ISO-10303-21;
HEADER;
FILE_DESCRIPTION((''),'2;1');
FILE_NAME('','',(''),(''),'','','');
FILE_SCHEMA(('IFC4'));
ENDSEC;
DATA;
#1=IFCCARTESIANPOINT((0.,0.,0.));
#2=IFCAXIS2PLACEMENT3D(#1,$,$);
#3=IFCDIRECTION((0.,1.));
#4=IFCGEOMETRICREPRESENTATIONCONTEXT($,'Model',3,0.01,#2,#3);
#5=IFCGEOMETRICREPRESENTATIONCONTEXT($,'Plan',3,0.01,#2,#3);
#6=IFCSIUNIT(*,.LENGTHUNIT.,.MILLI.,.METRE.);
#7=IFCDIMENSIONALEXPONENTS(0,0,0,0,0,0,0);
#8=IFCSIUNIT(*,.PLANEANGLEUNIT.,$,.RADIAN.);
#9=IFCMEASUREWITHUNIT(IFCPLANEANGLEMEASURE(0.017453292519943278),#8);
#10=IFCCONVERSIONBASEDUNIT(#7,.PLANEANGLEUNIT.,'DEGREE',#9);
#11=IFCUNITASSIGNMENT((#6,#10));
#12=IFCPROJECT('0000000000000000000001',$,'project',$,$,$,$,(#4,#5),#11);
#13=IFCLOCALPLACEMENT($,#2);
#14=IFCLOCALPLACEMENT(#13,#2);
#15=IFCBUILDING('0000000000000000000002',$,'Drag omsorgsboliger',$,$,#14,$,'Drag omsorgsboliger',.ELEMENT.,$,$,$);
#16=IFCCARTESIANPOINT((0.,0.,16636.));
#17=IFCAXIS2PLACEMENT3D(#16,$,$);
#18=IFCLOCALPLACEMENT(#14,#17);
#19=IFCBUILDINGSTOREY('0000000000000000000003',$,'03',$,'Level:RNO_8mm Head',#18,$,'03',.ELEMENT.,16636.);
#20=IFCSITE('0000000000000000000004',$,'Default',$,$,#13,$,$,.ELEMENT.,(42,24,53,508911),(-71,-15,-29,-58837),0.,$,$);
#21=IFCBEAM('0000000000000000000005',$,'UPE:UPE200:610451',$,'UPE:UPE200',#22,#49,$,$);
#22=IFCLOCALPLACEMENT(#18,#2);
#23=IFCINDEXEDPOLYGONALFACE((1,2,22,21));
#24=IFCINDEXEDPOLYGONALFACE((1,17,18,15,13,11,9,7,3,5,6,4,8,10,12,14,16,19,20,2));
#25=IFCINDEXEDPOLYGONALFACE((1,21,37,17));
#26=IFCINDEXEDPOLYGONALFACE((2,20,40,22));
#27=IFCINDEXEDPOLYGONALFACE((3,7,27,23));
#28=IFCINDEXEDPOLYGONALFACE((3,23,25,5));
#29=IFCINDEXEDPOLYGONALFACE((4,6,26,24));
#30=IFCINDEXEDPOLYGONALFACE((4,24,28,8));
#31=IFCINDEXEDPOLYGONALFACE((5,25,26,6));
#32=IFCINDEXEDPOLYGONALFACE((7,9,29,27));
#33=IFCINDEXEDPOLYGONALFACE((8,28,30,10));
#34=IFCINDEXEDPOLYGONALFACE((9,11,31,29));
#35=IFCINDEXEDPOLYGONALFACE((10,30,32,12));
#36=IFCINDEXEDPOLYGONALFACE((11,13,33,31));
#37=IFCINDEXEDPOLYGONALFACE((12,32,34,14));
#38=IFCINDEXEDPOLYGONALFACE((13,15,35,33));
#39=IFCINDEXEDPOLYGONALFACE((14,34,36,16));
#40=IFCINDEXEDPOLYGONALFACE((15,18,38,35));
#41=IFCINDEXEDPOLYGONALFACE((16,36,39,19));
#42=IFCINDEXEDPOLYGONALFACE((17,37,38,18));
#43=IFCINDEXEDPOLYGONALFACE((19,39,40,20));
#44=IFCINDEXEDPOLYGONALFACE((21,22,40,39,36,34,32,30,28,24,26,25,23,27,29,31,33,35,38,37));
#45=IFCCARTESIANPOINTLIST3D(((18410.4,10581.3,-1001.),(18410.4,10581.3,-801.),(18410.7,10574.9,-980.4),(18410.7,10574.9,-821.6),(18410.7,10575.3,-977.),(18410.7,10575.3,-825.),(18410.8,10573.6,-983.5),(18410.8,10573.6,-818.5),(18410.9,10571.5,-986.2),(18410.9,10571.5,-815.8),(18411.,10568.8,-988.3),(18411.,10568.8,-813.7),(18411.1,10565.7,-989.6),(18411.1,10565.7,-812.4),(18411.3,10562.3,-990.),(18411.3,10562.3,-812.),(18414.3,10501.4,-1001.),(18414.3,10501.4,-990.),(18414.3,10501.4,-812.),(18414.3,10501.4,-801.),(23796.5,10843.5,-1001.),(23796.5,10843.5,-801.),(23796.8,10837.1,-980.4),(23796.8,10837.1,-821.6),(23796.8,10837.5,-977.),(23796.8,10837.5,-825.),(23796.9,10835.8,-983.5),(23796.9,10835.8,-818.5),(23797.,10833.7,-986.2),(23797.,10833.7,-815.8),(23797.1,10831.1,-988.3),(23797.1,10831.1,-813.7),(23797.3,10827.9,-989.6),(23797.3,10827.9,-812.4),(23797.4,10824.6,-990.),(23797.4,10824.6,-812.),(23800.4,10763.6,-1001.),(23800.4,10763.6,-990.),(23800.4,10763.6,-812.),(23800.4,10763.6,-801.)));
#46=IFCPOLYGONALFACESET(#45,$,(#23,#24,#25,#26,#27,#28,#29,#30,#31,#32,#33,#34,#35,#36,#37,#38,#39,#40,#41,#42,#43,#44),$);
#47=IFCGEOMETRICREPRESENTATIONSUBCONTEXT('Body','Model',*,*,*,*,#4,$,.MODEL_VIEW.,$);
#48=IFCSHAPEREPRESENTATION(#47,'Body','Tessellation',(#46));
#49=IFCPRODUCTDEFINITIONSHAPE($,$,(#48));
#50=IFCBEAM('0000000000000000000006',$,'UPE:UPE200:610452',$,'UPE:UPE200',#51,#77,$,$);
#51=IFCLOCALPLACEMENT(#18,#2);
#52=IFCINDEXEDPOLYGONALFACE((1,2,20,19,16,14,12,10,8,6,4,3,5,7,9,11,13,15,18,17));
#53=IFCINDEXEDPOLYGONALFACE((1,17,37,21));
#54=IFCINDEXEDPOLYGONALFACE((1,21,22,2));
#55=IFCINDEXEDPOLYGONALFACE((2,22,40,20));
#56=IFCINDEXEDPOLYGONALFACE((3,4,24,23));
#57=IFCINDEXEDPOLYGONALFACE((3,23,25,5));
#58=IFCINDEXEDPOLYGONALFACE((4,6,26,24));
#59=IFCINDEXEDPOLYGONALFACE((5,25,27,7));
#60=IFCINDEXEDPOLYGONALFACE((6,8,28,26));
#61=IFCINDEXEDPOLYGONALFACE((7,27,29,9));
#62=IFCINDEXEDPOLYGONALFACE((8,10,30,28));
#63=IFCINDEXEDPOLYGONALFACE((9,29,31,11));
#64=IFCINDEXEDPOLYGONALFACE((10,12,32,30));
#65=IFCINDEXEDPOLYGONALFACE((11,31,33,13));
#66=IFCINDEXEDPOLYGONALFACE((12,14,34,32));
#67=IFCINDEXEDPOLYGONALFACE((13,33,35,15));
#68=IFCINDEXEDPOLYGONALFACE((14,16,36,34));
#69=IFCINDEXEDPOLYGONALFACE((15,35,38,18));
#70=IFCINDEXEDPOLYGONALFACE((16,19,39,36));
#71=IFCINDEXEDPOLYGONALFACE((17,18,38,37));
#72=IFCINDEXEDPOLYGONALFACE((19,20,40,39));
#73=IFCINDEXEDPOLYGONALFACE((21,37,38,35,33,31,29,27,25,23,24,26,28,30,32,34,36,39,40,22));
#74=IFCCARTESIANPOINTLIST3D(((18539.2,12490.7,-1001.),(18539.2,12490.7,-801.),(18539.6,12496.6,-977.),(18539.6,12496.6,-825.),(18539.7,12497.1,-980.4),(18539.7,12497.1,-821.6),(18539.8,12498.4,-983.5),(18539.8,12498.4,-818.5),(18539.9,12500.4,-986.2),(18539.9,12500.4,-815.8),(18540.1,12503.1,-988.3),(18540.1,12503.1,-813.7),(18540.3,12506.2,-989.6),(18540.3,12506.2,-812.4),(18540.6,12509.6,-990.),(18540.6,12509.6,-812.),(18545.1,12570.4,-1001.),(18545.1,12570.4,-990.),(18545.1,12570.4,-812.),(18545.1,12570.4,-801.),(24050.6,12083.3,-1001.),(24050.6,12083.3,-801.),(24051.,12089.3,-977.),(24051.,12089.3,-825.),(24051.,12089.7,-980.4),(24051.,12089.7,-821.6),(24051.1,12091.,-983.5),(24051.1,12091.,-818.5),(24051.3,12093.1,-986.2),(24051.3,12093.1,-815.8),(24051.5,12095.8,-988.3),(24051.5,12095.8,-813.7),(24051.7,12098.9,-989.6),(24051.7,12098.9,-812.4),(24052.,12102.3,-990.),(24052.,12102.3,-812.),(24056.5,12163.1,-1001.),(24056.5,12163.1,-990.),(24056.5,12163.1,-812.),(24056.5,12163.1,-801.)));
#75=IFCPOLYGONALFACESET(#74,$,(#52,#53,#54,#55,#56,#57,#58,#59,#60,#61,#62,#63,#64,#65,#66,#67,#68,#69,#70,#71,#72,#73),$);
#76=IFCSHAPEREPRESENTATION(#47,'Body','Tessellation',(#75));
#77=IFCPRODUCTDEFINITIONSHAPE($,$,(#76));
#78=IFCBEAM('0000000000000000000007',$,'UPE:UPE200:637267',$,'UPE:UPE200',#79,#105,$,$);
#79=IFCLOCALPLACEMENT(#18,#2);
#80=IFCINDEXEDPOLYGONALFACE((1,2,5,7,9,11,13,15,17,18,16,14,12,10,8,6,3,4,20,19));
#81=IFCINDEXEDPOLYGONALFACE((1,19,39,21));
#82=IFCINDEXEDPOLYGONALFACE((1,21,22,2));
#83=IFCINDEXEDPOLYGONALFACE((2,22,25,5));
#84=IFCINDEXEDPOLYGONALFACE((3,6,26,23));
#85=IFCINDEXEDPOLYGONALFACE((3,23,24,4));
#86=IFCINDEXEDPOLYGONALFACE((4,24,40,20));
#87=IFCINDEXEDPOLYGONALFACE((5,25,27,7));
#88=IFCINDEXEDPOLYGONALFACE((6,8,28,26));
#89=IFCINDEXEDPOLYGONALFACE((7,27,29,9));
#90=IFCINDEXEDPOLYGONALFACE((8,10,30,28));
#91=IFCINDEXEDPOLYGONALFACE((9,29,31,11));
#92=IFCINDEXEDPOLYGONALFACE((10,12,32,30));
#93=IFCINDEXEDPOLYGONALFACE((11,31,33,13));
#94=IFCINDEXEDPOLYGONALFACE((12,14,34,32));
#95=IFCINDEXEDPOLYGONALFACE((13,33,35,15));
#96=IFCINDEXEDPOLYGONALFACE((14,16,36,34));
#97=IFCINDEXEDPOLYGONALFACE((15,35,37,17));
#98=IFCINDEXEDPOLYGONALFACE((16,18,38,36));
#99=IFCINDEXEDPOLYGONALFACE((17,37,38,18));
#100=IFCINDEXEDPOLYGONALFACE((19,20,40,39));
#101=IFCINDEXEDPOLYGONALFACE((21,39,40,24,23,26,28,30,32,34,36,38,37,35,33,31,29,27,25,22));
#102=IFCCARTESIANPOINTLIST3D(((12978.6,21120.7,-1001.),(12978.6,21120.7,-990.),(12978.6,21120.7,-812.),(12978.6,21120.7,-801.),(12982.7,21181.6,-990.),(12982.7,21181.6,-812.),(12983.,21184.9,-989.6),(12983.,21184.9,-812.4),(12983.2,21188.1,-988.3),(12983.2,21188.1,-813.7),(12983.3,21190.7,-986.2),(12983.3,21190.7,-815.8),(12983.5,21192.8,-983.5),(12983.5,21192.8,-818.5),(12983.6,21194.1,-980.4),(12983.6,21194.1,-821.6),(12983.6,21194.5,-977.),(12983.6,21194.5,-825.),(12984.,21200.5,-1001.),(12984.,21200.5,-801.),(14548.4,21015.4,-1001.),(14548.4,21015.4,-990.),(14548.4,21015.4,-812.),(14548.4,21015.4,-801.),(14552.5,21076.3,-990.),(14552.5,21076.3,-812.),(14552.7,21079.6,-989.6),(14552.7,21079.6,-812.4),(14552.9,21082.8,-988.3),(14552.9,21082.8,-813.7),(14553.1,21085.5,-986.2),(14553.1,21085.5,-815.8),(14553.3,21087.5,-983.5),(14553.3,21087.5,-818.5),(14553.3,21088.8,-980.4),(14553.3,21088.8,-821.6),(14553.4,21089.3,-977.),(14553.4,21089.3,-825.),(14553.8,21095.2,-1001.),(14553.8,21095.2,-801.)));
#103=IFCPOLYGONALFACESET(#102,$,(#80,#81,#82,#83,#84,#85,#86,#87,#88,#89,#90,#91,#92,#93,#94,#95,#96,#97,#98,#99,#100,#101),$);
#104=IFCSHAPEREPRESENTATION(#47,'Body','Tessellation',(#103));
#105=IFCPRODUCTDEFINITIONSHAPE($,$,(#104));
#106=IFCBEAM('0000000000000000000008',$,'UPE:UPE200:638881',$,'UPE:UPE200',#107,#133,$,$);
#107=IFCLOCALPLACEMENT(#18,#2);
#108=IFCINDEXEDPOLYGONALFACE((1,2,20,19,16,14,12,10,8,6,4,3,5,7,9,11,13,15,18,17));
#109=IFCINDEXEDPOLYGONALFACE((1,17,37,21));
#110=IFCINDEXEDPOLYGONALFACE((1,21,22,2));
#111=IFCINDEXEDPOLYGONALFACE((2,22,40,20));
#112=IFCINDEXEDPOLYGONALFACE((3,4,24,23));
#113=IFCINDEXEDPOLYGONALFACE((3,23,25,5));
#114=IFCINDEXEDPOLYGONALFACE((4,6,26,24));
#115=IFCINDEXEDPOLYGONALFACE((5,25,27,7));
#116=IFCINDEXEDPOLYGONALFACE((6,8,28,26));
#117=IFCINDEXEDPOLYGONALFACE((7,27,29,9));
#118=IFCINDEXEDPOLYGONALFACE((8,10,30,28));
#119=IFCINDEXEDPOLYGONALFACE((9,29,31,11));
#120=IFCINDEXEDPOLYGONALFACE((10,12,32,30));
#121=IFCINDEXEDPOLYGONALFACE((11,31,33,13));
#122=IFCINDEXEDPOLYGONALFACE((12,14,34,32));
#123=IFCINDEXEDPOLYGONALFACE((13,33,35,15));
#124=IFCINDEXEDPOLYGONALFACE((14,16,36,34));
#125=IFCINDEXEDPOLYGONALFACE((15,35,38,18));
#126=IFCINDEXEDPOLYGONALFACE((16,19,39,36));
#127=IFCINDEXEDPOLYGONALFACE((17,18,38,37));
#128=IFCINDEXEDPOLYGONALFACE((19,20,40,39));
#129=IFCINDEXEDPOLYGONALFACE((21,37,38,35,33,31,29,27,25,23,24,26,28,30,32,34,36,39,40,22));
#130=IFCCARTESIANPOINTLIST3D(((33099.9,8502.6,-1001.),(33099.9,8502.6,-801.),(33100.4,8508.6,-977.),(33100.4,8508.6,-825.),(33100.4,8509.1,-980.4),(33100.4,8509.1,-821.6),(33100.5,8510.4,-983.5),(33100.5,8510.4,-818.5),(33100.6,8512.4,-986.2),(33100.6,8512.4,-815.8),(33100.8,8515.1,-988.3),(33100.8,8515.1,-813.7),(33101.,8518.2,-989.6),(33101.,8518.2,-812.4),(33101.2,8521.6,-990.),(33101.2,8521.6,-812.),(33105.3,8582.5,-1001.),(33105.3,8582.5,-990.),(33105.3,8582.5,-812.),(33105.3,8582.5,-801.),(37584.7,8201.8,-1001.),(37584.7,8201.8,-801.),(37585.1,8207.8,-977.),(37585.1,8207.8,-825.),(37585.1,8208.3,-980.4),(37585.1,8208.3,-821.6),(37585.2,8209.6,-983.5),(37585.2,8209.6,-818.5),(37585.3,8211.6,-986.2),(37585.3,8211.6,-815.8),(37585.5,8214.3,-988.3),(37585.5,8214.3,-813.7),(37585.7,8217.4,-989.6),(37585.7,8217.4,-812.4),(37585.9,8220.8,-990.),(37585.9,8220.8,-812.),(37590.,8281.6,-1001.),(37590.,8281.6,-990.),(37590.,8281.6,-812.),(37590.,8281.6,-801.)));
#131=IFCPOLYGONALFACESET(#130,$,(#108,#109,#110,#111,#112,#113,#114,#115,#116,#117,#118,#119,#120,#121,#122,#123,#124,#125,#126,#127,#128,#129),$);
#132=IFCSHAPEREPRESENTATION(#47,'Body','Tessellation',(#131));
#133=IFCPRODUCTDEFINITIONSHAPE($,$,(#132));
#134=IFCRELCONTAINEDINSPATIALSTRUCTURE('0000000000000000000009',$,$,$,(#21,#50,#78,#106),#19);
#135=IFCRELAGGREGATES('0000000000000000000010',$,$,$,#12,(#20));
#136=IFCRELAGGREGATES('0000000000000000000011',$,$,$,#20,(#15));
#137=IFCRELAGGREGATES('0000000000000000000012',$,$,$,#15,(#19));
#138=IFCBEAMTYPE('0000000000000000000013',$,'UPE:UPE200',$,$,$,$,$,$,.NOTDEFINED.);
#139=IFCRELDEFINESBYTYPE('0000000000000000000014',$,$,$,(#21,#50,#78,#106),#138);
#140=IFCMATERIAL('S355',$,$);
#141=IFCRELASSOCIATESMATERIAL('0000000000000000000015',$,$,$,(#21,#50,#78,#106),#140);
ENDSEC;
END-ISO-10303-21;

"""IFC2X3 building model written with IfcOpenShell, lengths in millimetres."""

from ifc_helpers import new_model, entity, si_unit, converted_unit, direction, frame, frame_2d, origin, place, context, subcontext, project, spatial, polyline, circle_curve, parameter, trimmed, segment, composite_curve, outline, extrude, material, type_object, element, save


model = new_model("IFC2X3")

# Units and contexts
model_context = context("Model", 3, precision=0.01, world=origin(), true_north=direction((0.0, 1.0)))
plan_context = context("Plan", 3, precision=0.01, world=origin(), true_north=direction((0.0, 1.0)))
body_context = subcontext(model_context, "Body", "Model", "MODEL_VIEW")
ifc_project = project(units=[si_unit("LENGTHUNIT", "METRE", prefix="MILLI"), converted_unit("PLANEANGLEUNIT", "DEGREE", entity("IfcPlaneAngleMeasure", 0.017453292519943278), si_unit("PLANEANGLEUNIT", "RADIAN"), dimensions=[0, 0, 0, 0, 0, 0, 0])], contexts=[model_context, plan_context])

# Site, building, storey
site_placement = place(None, origin())
site = spatial("IfcSite", under=ifc_project, at=site_placement, Name="Default", CompositionType="ELEMENT", RefLatitude=(42, 24, 53, 508911), RefLongitude=(-71, -15, -29, -58837), RefElevation=0.0)
building_placement = place(site_placement, origin())
building = spatial("IfcBuilding", under=site, at=building_placement, Name="Drag omsorgsboliger", LongName="Drag omsorgsboliger", CompositionType="ELEMENT")
storey_placement = place(building_placement, frame((0.0, 0.0, 16636.0)))
storey = spatial("IfcBuildingStorey", under=building, at=storey_placement, Name="03", ObjectType="Level:RNO_8mm Head", LongName="03", CompositionType="ELEMENT", Elevation=16636.0)

# Beams
ifc_material = material(Name="S355")
beam_type_1 = type_object("IfcBeamType", Name="UPE:UPE200", PredefinedType="NOTDEFINED")
beam_1_placement = place(storey_placement, frame((23879.2, 10821.9, -801.0), z_axis=(0.0, 0.0, 1.0), x_axis=(-0.998817, -0.048632, 0.0)))
element("IfcBeam", 1, at=beam_1_placement, inside=storey, type_object=beam_type_1, material=ifc_material, Name="UPE:UPE200:610451", ObjectType="UPE:UPE200", context=body_context, shape_type="SweptSolid", body=[
    extrude(outline(composite_curve([segment(polyline([(-100.0, -37.0), (100.0, -37.0)]), True, "CONTINUOUS"), segment(polyline([(100.0, -37.0), (100.0, 43.0)]), True, "CONTINUOUS"), segment(polyline([(100.0, 43.0), (89.0, 43.0)]), True, "CONTINUOUS"), segment(polyline([(89.0, 43.0), (89.0, -18.0)]), True, "CONTINUOUS"), segment(trimmed(circle_curve(frame_2d((76.0, -18.0), x_axis=(1.0, 0.0)), 13.0), [parameter(270.0)], [parameter(0.0)], True, "PARAMETER"), False, "CONTINUOUS"), segment(polyline([(76.0, -31.0), (-76.0, -31.0)]), True, "CONTINUOUS"), segment(trimmed(circle_curve(frame_2d((-76.0, -18.0), x_axis=(0.0, -1.0)), 13.0), [parameter(270.0)], [parameter(0.0)], True, "PARAMETER"), False, "CONTINUOUS"), segment(polyline([(-89.0, -18.0), (-89.0, 43.0)]), True, "CONTINUOUS"), segment(polyline([(-89.0, 43.0), (-100.0, 43.0)]), True, "CONTINUOUS"), segment(polyline([(-100.0, 43.0), (-100.0, -37.0)]), True, "CONTINUOUS")], self_intersect=False)), frame((81.5, 11.4, -100.0), z_axis=(1.0, 0.0, 0.0), x_axis=(0.0, 0.0, -1.0)), (0.0, 0.0, 1.0), 5392.5),
])
beam_2_placement = place(storey_placement, frame((18594.6, 12512.2, -801.0), z_axis=(0.0, 0.0, 1.0), x_axis=(0.99728, -0.073706, 0.0)))
element("IfcBeam", 2, at=beam_2_placement, inside=storey, type_object=beam_type_1, material=ifc_material, Name="UPE:UPE200:610452", ObjectType="UPE:UPE200", context=body_context, shape_type="SweptSolid", body=[
    extrude(outline(composite_curve([segment(polyline([(-100.0, -37.0), (100.0, -37.0)]), True, "CONTINUOUS"), segment(polyline([(100.0, -37.0), (100.0, 43.0)]), True, "CONTINUOUS"), segment(polyline([(100.0, 43.0), (89.0, 43.0)]), True, "CONTINUOUS"), segment(polyline([(89.0, 43.0), (89.0, -18.0)]), True, "CONTINUOUS"), segment(trimmed(circle_curve(frame_2d((76.0, -18.0), x_axis=(1.0, 0.0)), 13.0), [parameter(270.0)], [parameter(0.0)], True, "PARAMETER"), False, "CONTINUOUS"), segment(polyline([(76.0, -31.0), (-76.0, -31.0)]), True, "CONTINUOUS"), segment(trimmed(circle_curve(frame_2d((-76.0, -18.0), x_axis=(0.0, -1.0)), 13.0), [parameter(270.0)], [parameter(0.0)], True, "PARAMETER"), False, "CONTINUOUS"), segment(polyline([(-89.0, -18.0), (-89.0, 43.0)]), True, "CONTINUOUS"), segment(polyline([(-89.0, 43.0), (-100.0, 43.0)]), True, "CONTINUOUS"), segment(polyline([(-100.0, 43.0), (-100.0, -37.0)]), True, "CONTINUOUS")], self_intersect=False)), frame((-53.7, 11.4, -100.0), z_axis=(1.0, 0.0, 0.0), x_axis=(0.0, 0.0, -1.0)), (0.0, 0.0, 1.0), 5526.4),
])
beam_3_placement = place(storey_placement, frame((14552.1, 21069.7, -801.0), z_axis=(0.0, 0.0, 1.0), x_axis=(-0.997758, 0.066923, 0.0)))
element("IfcBeam", 3, at=beam_3_placement, inside=storey, type_object=beam_type_1, material=ifc_material, Name="UPE:UPE200:637267", ObjectType="UPE:UPE200", context=body_context, shape_type="SweptSolid", body=[
    extrude(outline(composite_curve([segment(polyline([(-100.0, -37.0), (100.0, -37.0)]), True, "CONTINUOUS"), segment(polyline([(100.0, -37.0), (100.0, 43.0)]), True, "CONTINUOUS"), segment(polyline([(100.0, 43.0), (89.0, 43.0)]), True, "CONTINUOUS"), segment(polyline([(89.0, 43.0), (89.0, -18.0)]), True, "CONTINUOUS"), segment(trimmed(circle_curve(frame_2d((76.0, -18.0), x_axis=(1.0, 0.0)), 13.0), [parameter(270.0)], [parameter(0.0)], True, "PARAMETER"), False, "CONTINUOUS"), segment(polyline([(76.0, -31.0), (-76.0, -31.0)]), True, "CONTINUOUS"), segment(trimmed(circle_curve(frame_2d((-76.0, -18.0), x_axis=(0.0, -1.0)), 13.0), [parameter(270.0)], [parameter(0.0)], True, "PARAMETER"), False, "CONTINUOUS"), segment(polyline([(-89.0, -18.0), (-89.0, 43.0)]), True, "CONTINUOUS"), segment(polyline([(-89.0, 43.0), (-100.0, 43.0)]), True, "CONTINUOUS"), segment(polyline([(-100.0, 43.0), (-100.0, -37.0)]), True, "CONTINUOUS")], self_intersect=False)), frame((0.0, 11.4, -100.0), z_axis=(1.0, 0.0, 0.0), x_axis=(0.0, 0.0, -1.0)), (0.0, 0.0, 1.0), 1573.3),
])
beam_4_placement = place(storey_placement, frame((33100.8, 8528.2, -801.0), z_axis=(0.0, 0.0, 1.0), x_axis=(0.997758, -0.066923, 0.0)))
element("IfcBeam", 4, at=beam_4_placement, inside=storey, type_object=beam_type_1, material=ifc_material, Name="UPE:UPE200:638881", ObjectType="UPE:UPE200", context=body_context, shape_type="SweptSolid", body=[
    extrude(outline(composite_curve([segment(polyline([(-100.0, -37.0), (100.0, -37.0)]), True, "CONTINUOUS"), segment(polyline([(100.0, -37.0), (100.0, 43.0)]), True, "CONTINUOUS"), segment(polyline([(100.0, 43.0), (89.0, 43.0)]), True, "CONTINUOUS"), segment(polyline([(89.0, 43.0), (89.0, -18.0)]), True, "CONTINUOUS"), segment(trimmed(circle_curve(frame_2d((76.0, -18.0), x_axis=(1.0, 0.0)), 13.0), [parameter(270.0)], [parameter(0.0)], True, "PARAMETER"), False, "CONTINUOUS"), segment(polyline([(76.0, -31.0), (-76.0, -31.0)]), True, "CONTINUOUS"), segment(trimmed(circle_curve(frame_2d((-76.0, -18.0), x_axis=(0.0, -1.0)), 13.0), [parameter(270.0)], [parameter(0.0)], True, "PARAMETER"), False, "CONTINUOUS"), segment(polyline([(-89.0, -18.0), (-89.0, 43.0)]), True, "CONTINUOUS"), segment(polyline([(-89.0, 43.0), (-100.0, 43.0)]), True, "CONTINUOUS"), segment(polyline([(-100.0, 43.0), (-100.0, -37.0)]), True, "CONTINUOUS")], self_intersect=False)), frame((0.8, 11.4, -100.0), z_axis=(1.0, 0.0, 0.0), x_axis=(0.0, 0.0, -1.0)), (0.0, 0.0, 1.0), 4494.8),
])

save(model, "model.ifc")
